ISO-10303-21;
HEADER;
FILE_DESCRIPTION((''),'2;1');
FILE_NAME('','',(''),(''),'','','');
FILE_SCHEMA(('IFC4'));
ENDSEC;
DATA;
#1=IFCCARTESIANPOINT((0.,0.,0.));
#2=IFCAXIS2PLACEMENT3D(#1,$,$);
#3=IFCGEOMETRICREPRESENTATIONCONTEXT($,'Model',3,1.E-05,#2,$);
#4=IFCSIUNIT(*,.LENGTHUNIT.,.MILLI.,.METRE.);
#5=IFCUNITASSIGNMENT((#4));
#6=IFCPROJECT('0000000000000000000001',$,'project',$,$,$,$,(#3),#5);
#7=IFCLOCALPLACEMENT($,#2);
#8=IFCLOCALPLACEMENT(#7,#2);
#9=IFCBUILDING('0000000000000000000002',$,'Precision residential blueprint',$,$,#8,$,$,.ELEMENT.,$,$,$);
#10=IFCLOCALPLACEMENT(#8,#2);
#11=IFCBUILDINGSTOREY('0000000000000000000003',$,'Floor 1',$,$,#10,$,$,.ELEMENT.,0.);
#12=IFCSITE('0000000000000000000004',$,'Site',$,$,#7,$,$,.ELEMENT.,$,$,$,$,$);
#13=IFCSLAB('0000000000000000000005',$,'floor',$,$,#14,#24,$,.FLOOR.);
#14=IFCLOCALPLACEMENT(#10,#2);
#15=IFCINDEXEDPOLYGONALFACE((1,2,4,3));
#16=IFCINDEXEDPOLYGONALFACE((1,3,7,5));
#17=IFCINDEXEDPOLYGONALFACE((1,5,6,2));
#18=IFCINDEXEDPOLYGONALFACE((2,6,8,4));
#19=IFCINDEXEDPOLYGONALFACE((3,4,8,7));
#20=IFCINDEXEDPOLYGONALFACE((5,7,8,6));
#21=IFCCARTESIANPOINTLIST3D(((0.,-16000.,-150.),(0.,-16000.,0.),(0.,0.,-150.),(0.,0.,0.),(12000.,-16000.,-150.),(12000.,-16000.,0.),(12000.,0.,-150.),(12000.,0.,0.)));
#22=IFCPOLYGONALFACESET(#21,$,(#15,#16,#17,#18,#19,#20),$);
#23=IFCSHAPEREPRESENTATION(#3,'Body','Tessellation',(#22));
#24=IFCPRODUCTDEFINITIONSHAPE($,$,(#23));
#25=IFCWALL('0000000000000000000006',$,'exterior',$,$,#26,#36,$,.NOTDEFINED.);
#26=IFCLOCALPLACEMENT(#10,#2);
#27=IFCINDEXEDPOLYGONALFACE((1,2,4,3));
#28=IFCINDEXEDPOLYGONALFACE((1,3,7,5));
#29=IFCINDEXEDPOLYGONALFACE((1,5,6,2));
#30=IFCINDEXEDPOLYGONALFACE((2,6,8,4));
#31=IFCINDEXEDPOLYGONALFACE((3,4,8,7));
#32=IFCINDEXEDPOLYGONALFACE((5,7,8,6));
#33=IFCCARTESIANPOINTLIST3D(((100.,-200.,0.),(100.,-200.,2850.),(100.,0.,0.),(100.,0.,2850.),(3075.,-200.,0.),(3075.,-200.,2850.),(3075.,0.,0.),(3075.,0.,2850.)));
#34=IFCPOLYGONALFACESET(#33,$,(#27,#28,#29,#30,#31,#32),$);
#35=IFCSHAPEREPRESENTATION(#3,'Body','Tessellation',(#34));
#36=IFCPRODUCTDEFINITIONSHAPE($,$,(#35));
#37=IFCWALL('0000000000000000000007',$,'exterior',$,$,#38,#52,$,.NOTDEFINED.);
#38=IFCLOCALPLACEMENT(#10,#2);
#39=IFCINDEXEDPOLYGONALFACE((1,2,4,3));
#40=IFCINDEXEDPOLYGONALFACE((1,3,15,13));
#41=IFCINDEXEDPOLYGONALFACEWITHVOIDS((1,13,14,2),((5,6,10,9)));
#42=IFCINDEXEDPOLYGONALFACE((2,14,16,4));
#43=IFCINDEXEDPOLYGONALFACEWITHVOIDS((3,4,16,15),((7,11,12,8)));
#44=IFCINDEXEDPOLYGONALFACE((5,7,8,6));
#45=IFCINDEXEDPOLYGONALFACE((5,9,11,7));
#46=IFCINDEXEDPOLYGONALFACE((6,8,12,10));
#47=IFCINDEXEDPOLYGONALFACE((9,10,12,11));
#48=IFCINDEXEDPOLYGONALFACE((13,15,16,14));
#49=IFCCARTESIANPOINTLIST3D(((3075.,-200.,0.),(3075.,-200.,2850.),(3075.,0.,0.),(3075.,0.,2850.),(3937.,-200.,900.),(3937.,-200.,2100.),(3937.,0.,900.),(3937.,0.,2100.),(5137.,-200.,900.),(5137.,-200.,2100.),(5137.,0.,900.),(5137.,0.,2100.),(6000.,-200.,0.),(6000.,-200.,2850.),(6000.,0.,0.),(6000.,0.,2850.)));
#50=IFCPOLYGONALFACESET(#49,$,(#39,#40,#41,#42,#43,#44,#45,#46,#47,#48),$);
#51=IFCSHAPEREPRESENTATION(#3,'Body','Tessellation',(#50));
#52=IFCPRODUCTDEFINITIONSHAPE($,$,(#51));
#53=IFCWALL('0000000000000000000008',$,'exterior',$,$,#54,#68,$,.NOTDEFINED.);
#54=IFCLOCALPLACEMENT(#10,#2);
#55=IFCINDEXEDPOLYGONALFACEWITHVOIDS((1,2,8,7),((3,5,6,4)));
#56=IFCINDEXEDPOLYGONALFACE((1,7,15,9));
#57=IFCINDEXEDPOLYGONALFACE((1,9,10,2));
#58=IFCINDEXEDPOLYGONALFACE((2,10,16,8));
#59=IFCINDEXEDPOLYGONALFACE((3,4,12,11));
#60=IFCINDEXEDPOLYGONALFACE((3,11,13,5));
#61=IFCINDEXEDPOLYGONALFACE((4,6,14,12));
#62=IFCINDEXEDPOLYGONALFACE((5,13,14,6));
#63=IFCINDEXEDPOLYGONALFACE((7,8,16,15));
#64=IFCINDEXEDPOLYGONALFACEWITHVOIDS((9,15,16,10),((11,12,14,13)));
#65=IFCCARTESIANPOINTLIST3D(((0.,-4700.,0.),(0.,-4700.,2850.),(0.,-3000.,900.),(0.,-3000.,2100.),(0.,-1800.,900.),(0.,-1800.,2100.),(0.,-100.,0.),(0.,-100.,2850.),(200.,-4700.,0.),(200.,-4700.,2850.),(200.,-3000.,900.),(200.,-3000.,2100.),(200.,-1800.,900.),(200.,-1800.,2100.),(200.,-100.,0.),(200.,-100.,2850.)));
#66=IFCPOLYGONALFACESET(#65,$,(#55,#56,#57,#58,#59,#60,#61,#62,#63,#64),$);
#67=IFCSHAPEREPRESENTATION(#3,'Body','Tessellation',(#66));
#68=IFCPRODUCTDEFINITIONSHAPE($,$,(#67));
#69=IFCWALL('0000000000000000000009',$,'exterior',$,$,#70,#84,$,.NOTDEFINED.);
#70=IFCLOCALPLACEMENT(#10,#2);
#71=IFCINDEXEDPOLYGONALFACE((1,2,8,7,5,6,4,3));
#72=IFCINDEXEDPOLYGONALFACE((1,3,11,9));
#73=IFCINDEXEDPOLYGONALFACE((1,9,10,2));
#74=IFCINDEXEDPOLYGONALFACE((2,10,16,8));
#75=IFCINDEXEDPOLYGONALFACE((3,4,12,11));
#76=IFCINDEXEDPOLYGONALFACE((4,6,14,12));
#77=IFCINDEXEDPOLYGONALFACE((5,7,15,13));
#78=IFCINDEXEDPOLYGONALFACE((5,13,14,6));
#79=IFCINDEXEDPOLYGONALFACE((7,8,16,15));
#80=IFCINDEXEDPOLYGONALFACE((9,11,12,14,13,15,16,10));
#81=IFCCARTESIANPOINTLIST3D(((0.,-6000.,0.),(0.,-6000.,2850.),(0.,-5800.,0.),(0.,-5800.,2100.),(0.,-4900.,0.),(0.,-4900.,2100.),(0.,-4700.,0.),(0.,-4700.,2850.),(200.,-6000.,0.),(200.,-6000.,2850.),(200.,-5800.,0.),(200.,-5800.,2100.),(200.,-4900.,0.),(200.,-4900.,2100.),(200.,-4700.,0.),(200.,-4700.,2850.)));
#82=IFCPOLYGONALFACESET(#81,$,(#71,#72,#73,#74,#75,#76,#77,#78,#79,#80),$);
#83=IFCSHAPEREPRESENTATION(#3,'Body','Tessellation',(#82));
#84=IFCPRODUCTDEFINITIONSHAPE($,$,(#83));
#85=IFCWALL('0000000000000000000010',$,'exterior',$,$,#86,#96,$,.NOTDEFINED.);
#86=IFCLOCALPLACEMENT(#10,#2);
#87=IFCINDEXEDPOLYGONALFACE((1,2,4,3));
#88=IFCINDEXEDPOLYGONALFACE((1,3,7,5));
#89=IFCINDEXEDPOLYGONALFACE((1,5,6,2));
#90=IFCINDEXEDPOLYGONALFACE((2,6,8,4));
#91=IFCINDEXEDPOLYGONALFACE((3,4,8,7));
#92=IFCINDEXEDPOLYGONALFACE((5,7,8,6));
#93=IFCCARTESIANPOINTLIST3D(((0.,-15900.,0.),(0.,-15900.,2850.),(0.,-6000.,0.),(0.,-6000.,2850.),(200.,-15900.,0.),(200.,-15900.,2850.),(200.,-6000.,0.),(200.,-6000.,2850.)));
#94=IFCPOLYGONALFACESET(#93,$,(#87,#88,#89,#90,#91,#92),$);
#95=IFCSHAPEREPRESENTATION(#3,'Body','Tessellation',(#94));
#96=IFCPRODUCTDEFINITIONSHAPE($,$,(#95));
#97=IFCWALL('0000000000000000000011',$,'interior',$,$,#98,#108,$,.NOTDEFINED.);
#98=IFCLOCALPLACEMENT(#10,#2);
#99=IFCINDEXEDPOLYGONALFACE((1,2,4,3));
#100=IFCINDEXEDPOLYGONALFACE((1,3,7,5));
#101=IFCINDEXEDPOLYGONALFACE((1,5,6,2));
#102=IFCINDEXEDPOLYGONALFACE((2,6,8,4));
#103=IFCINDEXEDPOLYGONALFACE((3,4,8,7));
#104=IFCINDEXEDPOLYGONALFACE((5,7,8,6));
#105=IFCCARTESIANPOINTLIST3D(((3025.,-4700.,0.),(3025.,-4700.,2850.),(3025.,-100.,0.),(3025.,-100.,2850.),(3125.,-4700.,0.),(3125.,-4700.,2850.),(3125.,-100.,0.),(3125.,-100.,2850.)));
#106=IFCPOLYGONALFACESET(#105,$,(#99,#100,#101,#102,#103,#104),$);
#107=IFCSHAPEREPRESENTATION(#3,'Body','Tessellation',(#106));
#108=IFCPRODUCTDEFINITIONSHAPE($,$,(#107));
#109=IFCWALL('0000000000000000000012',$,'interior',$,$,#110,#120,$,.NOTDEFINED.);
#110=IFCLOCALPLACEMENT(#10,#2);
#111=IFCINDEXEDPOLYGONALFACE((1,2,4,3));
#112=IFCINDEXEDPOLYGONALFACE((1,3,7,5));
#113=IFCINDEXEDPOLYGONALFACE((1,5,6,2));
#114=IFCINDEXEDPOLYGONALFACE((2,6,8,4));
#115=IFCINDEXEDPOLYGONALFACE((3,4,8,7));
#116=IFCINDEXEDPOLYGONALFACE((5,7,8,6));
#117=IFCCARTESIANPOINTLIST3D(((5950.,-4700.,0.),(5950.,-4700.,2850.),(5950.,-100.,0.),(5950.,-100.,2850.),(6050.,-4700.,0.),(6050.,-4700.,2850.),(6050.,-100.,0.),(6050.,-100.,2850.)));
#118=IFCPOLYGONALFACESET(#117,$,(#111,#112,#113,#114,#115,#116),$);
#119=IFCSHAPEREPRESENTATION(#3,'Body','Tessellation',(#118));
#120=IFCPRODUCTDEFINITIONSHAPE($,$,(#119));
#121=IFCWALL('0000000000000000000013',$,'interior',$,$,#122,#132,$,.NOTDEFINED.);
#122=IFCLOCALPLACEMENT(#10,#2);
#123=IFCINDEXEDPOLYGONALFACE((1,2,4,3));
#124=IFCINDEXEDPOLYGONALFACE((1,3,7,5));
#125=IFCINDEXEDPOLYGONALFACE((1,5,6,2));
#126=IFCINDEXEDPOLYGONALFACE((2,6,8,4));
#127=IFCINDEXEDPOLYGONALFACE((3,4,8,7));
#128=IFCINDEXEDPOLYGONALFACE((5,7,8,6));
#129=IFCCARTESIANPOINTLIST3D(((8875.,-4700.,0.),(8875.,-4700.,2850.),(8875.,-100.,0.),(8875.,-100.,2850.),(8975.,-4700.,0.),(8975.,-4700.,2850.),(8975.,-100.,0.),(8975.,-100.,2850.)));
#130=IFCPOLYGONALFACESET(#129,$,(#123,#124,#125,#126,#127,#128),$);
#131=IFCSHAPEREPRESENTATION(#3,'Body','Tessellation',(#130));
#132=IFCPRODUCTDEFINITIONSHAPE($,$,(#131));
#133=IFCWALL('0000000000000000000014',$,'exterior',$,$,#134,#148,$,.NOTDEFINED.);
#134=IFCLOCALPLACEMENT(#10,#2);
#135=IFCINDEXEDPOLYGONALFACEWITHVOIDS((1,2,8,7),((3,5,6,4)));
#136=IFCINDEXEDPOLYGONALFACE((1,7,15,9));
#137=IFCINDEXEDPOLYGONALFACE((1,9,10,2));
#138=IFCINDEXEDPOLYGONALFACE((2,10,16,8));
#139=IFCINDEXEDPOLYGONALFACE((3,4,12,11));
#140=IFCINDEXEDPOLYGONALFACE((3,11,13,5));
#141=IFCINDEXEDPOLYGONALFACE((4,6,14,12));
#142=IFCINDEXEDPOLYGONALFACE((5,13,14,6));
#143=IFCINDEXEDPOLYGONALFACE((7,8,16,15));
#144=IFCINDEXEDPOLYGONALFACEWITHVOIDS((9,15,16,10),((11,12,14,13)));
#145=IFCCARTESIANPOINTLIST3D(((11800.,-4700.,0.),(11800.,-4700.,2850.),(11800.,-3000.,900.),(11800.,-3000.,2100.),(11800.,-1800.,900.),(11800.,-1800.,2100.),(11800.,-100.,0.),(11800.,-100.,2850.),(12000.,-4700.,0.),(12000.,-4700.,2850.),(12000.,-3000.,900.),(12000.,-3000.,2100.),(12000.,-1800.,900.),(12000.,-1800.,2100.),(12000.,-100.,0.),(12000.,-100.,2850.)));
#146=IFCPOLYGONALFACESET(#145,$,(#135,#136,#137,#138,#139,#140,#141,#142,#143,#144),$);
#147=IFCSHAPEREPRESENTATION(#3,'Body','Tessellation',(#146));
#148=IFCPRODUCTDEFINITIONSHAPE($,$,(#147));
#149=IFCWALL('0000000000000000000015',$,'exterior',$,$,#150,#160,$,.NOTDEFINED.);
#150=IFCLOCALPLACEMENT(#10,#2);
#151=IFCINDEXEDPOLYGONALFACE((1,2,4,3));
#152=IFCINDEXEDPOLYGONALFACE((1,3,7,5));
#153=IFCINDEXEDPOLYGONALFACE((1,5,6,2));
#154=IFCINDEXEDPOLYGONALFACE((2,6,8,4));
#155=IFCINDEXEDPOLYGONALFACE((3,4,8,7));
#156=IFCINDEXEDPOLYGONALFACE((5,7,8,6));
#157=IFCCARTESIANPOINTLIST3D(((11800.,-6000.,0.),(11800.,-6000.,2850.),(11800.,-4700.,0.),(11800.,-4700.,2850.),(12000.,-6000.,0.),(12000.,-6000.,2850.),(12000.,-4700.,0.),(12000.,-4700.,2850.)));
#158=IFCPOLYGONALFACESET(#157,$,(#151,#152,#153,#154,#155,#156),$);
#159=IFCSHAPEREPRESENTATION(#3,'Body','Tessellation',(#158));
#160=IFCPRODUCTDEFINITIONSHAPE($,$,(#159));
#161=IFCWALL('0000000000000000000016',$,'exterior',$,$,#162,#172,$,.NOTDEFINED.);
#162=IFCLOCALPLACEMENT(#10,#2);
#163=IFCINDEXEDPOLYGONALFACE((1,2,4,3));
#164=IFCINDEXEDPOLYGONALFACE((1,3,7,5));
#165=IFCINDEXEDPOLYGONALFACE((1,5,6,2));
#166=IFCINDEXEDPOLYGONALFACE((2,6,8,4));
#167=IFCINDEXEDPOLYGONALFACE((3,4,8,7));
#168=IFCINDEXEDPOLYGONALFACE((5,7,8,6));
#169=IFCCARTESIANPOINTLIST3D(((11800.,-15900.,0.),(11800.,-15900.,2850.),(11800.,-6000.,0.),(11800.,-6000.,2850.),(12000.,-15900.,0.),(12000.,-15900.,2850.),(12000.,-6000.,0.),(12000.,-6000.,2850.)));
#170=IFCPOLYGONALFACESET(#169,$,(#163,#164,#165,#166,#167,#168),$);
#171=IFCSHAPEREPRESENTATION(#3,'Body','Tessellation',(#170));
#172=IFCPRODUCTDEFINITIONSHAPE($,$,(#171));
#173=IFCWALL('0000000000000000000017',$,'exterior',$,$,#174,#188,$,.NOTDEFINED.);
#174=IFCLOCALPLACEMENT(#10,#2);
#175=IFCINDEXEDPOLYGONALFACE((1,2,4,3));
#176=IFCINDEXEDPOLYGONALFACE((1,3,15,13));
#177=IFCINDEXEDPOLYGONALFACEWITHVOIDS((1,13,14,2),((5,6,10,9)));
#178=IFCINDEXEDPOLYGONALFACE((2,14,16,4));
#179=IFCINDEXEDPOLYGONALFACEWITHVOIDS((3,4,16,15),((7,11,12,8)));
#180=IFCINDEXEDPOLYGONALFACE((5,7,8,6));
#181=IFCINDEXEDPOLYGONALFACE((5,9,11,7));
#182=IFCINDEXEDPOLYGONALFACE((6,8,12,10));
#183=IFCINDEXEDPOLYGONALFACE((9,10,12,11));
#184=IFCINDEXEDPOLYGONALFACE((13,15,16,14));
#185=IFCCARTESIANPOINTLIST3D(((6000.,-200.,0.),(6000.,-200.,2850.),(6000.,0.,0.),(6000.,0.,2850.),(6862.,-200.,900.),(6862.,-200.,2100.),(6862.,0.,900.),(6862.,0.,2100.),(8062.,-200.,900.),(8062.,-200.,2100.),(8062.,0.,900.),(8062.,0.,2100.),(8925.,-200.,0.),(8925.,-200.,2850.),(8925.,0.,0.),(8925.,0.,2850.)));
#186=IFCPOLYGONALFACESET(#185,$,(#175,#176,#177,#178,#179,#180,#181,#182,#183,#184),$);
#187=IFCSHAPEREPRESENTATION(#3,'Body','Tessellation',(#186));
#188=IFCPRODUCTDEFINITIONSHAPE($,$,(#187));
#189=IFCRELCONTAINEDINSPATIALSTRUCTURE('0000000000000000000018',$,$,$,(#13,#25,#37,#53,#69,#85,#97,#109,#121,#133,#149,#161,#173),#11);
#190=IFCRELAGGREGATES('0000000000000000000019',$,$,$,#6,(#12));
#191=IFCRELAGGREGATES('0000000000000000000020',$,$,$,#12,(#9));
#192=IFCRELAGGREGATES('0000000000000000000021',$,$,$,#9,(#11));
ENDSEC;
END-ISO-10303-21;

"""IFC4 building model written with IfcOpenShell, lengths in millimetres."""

from ifc_helpers import new_model, si_unit, frame, origin, place, context, project, spatial, polyline, outline, extrude, element, save


model = new_model("IFC4")

# Units and contexts
model_context = context("Model", 3, precision=1e-05, world=origin())
ifc_project = project(units=[si_unit("LENGTHUNIT", "METRE", prefix="MILLI")], contexts=[model_context])

# Site, building, storey
site_placement = place(None, origin())
site = spatial("IfcSite", under=ifc_project, at=site_placement, Name="Site", CompositionType="ELEMENT")
building_placement = place(site_placement, origin())
building = spatial("IfcBuilding", under=site, at=building_placement, Name="Precision residential blueprint", CompositionType="ELEMENT")
storey_placement = place(building_placement, origin())
storey = spatial("IfcBuildingStorey", under=building, at=storey_placement, Name="Floor 1", CompositionType="ELEMENT", Elevation=0.0)

# Slab
slab_placement = place(storey_placement, origin())
element("IfcSlab", 1, at=slab_placement, inside=storey, Name="floor", PredefinedType="FLOOR", context=model_context, shape_type="SweptSolid", body=[
    extrude(outline(polyline([(0.0, -16000.0), (12000.0, -16000.0), (12000.0, 0.0), (0.0, 0.0), (0.0, -16000.0)])), frame((0.0, 0.0, -150.0)), (0.0, 0.0, 1.0), 150.0),
])

# Wall
wall_1_placement = place(storey_placement, origin())
element("IfcWall", 2, at=wall_1_placement, inside=storey, Name="exterior", PredefinedType="NOTDEFINED", context=model_context, shape_type="SweptSolid", body=[
    extrude(outline(polyline([(100.0, 0.0), (3075.0, 0.0), (3075.0, -200.0), (100.0, -200.0), (100.0, 0.0)])), origin(), (0.0, 0.0, 1.0), 2850.0),
])

# Walls, openings
wall_2_placement = place(storey_placement, origin())
wall_2 = element("IfcWall", 3, at=wall_2_placement, inside=storey, Name="exterior", PredefinedType="NOTDEFINED", context=model_context, shape_type="SweptSolid", body=[
    extrude(outline(polyline([(3075.0, 0.0), (6000.0, 0.0), (6000.0, -200.0), (3075.0, -200.0), (3075.0, 0.0)])), origin(), (0.0, 0.0, 1.0), 2850.0),
])
opening_1_placement = place(storey_placement, origin())
element("IfcOpeningElement", 4, at=opening_1_placement, cuts=wall_2, PredefinedType="OPENING", context=model_context, shape_type="SweptSolid", body=[
    extrude(outline(polyline([(3937.0, 0.0), (5137.0, 0.0), (5137.0, -200.0), (3937.0, -200.0), (3937.0, 0.0)])), frame((0.0, 0.0, 900.0)), (0.0, 0.0, 1.0), 1200.0),
])
wall_3_placement = place(storey_placement, origin())
wall_3 = element("IfcWall", 5, at=wall_3_placement, inside=storey, Name="exterior", PredefinedType="NOTDEFINED", context=model_context, shape_type="SweptSolid", body=[
    extrude(outline(polyline([(200.0, -100.0), (200.0, -4700.0), (0.0, -4700.0), (0.0, -100.0), (200.0, -100.0)])), origin(), (0.0, 0.0, 1.0), 2850.0),
])
opening_2_placement = place(storey_placement, origin())
element("IfcOpeningElement", 6, at=opening_2_placement, cuts=wall_3, PredefinedType="OPENING", context=model_context, shape_type="SweptSolid", body=[
    extrude(outline(polyline([(200.0, -1800.0), (200.0, -3000.0), (0.0, -3000.0), (0.0, -1800.0), (200.0, -1800.0)])), frame((0.0, 0.0, 900.0)), (0.0, 0.0, 1.0), 1200.0),
])
wall_4_placement = place(storey_placement, origin())
wall_4 = element("IfcWall", 7, at=wall_4_placement, inside=storey, Name="exterior", PredefinedType="NOTDEFINED", context=model_context, shape_type="SweptSolid", body=[
    extrude(outline(polyline([(200.0, -4700.0), (200.0, -6000.0), (0.0, -6000.0), (0.0, -4700.0), (200.0, -4700.0)])), origin(), (0.0, 0.0, 1.0), 2850.0),
])
opening_3_placement = place(storey_placement, origin())
element("IfcOpeningElement", 8, at=opening_3_placement, cuts=wall_4, PredefinedType="OPENING", context=model_context, shape_type="SweptSolid", body=[
    extrude(outline(polyline([(200.0, -4900.0), (200.0, -5800.0), (0.0, -5800.0), (0.0, -4900.0), (200.0, -4900.0)])), origin(), (0.0, 0.0, 1.0), 2100.0),
])

# Walls
wall_5_placement = place(storey_placement, origin())
element("IfcWall", 9, at=wall_5_placement, inside=storey, Name="exterior", PredefinedType="NOTDEFINED", context=model_context, shape_type="SweptSolid", body=[
    extrude(outline(polyline([(200.0, -6000.0), (200.0, -15900.0), (0.0, -15900.0), (0.0, -6000.0), (200.0, -6000.0)])), origin(), (0.0, 0.0, 1.0), 2850.0),
])
wall_6_placement = place(storey_placement, origin())
element("IfcWall", 10, at=wall_6_placement, inside=storey, Name="interior", PredefinedType="NOTDEFINED", context=model_context, shape_type="SweptSolid", body=[
    extrude(outline(polyline([(3125.0, -100.0), (3125.0, -4700.0), (3025.0, -4700.0), (3025.0, -100.0), (3125.0, -100.0)])), origin(), (0.0, 0.0, 1.0), 2850.0),
])
wall_7_placement = place(storey_placement, origin())
element("IfcWall", 11, at=wall_7_placement, inside=storey, Name="interior", PredefinedType="NOTDEFINED", context=model_context, shape_type="SweptSolid", body=[
    extrude(outline(polyline([(6050.0, -100.0), (6050.0, -4700.0), (5950.0, -4700.0), (5950.0, -100.0), (6050.0, -100.0)])), origin(), (0.0, 0.0, 1.0), 2850.0),
])
wall_8_placement = place(storey_placement, origin())
element("IfcWall", 12, at=wall_8_placement, inside=storey, Name="interior", PredefinedType="NOTDEFINED", context=model_context, shape_type="SweptSolid", body=[
    extrude(outline(polyline([(8975.0, -100.0), (8975.0, -4700.0), (8875.0, -4700.0), (8875.0, -100.0), (8975.0, -100.0)])), origin(), (0.0, 0.0, 1.0), 2850.0),
])

# Wall, opening
wall_9_placement = place(storey_placement, origin())
wall_9 = element("IfcWall", 13, at=wall_9_placement, inside=storey, Name="exterior", PredefinedType="NOTDEFINED", context=model_context, shape_type="SweptSolid", body=[
    extrude(outline(polyline([(12000.0, -100.0), (12000.0, -4700.0), (11800.0, -4700.0), (11800.0, -100.0), (12000.0, -100.0)])), origin(), (0.0, 0.0, 1.0), 2850.0),
])
opening_4_placement = place(storey_placement, origin())
element("IfcOpeningElement", 14, at=opening_4_placement, cuts=wall_9, PredefinedType="OPENING", context=model_context, shape_type="SweptSolid", body=[
    extrude(outline(polyline([(12000.0, -1800.0), (12000.0, -3000.0), (11800.0, -3000.0), (11800.0, -1800.0), (12000.0, -1800.0)])), frame((0.0, 0.0, 900.0)), (0.0, 0.0, 1.0), 1200.0),
])

# Walls
wall_10_placement = place(storey_placement, origin())
element("IfcWall", 15, at=wall_10_placement, inside=storey, Name="exterior", PredefinedType="NOTDEFINED", context=model_context, shape_type="SweptSolid", body=[
    extrude(outline(polyline([(12000.0, -4700.0), (12000.0, -6000.0), (11800.0, -6000.0), (11800.0, -4700.0), (12000.0, -4700.0)])), origin(), (0.0, 0.0, 1.0), 2850.0),
])
wall_11_placement = place(storey_placement, origin())
element("IfcWall", 16, at=wall_11_placement, inside=storey, Name="exterior", PredefinedType="NOTDEFINED", context=model_context, shape_type="SweptSolid", body=[
    extrude(outline(polyline([(12000.0, -6000.0), (12000.0, -15900.0), (11800.0, -15900.0), (11800.0, -6000.0), (12000.0, -6000.0)])), origin(), (0.0, 0.0, 1.0), 2850.0),
])

# Wall, opening
wall_12_placement = place(storey_placement, origin())
wall_12 = element("IfcWall", 17, at=wall_12_placement, inside=storey, Name="exterior", PredefinedType="NOTDEFINED", context=model_context, shape_type="SweptSolid", body=[
    extrude(outline(polyline([(6000.0, 0.0), (8925.0, 0.0), (8925.0, -200.0), (6000.0, -200.0), (6000.0, 0.0)])), origin(), (0.0, 0.0, 1.0), 2850.0),
])
opening_5_placement = place(storey_placement, origin())
element("IfcOpeningElement", 18, at=opening_5_placement, cuts=wall_12, PredefinedType="OPENING", context=model_context, shape_type="SweptSolid", body=[
    extrude(outline(polyline([(6862.0, 0.0), (8062.0, 0.0), (8062.0, -200.0), (6862.0, -200.0), (6862.0, 0.0)])), frame((0.0, 0.0, 900.0)), (0.0, 0.0, 1.0), 1200.0),
])

save(model, "model.ifc")
